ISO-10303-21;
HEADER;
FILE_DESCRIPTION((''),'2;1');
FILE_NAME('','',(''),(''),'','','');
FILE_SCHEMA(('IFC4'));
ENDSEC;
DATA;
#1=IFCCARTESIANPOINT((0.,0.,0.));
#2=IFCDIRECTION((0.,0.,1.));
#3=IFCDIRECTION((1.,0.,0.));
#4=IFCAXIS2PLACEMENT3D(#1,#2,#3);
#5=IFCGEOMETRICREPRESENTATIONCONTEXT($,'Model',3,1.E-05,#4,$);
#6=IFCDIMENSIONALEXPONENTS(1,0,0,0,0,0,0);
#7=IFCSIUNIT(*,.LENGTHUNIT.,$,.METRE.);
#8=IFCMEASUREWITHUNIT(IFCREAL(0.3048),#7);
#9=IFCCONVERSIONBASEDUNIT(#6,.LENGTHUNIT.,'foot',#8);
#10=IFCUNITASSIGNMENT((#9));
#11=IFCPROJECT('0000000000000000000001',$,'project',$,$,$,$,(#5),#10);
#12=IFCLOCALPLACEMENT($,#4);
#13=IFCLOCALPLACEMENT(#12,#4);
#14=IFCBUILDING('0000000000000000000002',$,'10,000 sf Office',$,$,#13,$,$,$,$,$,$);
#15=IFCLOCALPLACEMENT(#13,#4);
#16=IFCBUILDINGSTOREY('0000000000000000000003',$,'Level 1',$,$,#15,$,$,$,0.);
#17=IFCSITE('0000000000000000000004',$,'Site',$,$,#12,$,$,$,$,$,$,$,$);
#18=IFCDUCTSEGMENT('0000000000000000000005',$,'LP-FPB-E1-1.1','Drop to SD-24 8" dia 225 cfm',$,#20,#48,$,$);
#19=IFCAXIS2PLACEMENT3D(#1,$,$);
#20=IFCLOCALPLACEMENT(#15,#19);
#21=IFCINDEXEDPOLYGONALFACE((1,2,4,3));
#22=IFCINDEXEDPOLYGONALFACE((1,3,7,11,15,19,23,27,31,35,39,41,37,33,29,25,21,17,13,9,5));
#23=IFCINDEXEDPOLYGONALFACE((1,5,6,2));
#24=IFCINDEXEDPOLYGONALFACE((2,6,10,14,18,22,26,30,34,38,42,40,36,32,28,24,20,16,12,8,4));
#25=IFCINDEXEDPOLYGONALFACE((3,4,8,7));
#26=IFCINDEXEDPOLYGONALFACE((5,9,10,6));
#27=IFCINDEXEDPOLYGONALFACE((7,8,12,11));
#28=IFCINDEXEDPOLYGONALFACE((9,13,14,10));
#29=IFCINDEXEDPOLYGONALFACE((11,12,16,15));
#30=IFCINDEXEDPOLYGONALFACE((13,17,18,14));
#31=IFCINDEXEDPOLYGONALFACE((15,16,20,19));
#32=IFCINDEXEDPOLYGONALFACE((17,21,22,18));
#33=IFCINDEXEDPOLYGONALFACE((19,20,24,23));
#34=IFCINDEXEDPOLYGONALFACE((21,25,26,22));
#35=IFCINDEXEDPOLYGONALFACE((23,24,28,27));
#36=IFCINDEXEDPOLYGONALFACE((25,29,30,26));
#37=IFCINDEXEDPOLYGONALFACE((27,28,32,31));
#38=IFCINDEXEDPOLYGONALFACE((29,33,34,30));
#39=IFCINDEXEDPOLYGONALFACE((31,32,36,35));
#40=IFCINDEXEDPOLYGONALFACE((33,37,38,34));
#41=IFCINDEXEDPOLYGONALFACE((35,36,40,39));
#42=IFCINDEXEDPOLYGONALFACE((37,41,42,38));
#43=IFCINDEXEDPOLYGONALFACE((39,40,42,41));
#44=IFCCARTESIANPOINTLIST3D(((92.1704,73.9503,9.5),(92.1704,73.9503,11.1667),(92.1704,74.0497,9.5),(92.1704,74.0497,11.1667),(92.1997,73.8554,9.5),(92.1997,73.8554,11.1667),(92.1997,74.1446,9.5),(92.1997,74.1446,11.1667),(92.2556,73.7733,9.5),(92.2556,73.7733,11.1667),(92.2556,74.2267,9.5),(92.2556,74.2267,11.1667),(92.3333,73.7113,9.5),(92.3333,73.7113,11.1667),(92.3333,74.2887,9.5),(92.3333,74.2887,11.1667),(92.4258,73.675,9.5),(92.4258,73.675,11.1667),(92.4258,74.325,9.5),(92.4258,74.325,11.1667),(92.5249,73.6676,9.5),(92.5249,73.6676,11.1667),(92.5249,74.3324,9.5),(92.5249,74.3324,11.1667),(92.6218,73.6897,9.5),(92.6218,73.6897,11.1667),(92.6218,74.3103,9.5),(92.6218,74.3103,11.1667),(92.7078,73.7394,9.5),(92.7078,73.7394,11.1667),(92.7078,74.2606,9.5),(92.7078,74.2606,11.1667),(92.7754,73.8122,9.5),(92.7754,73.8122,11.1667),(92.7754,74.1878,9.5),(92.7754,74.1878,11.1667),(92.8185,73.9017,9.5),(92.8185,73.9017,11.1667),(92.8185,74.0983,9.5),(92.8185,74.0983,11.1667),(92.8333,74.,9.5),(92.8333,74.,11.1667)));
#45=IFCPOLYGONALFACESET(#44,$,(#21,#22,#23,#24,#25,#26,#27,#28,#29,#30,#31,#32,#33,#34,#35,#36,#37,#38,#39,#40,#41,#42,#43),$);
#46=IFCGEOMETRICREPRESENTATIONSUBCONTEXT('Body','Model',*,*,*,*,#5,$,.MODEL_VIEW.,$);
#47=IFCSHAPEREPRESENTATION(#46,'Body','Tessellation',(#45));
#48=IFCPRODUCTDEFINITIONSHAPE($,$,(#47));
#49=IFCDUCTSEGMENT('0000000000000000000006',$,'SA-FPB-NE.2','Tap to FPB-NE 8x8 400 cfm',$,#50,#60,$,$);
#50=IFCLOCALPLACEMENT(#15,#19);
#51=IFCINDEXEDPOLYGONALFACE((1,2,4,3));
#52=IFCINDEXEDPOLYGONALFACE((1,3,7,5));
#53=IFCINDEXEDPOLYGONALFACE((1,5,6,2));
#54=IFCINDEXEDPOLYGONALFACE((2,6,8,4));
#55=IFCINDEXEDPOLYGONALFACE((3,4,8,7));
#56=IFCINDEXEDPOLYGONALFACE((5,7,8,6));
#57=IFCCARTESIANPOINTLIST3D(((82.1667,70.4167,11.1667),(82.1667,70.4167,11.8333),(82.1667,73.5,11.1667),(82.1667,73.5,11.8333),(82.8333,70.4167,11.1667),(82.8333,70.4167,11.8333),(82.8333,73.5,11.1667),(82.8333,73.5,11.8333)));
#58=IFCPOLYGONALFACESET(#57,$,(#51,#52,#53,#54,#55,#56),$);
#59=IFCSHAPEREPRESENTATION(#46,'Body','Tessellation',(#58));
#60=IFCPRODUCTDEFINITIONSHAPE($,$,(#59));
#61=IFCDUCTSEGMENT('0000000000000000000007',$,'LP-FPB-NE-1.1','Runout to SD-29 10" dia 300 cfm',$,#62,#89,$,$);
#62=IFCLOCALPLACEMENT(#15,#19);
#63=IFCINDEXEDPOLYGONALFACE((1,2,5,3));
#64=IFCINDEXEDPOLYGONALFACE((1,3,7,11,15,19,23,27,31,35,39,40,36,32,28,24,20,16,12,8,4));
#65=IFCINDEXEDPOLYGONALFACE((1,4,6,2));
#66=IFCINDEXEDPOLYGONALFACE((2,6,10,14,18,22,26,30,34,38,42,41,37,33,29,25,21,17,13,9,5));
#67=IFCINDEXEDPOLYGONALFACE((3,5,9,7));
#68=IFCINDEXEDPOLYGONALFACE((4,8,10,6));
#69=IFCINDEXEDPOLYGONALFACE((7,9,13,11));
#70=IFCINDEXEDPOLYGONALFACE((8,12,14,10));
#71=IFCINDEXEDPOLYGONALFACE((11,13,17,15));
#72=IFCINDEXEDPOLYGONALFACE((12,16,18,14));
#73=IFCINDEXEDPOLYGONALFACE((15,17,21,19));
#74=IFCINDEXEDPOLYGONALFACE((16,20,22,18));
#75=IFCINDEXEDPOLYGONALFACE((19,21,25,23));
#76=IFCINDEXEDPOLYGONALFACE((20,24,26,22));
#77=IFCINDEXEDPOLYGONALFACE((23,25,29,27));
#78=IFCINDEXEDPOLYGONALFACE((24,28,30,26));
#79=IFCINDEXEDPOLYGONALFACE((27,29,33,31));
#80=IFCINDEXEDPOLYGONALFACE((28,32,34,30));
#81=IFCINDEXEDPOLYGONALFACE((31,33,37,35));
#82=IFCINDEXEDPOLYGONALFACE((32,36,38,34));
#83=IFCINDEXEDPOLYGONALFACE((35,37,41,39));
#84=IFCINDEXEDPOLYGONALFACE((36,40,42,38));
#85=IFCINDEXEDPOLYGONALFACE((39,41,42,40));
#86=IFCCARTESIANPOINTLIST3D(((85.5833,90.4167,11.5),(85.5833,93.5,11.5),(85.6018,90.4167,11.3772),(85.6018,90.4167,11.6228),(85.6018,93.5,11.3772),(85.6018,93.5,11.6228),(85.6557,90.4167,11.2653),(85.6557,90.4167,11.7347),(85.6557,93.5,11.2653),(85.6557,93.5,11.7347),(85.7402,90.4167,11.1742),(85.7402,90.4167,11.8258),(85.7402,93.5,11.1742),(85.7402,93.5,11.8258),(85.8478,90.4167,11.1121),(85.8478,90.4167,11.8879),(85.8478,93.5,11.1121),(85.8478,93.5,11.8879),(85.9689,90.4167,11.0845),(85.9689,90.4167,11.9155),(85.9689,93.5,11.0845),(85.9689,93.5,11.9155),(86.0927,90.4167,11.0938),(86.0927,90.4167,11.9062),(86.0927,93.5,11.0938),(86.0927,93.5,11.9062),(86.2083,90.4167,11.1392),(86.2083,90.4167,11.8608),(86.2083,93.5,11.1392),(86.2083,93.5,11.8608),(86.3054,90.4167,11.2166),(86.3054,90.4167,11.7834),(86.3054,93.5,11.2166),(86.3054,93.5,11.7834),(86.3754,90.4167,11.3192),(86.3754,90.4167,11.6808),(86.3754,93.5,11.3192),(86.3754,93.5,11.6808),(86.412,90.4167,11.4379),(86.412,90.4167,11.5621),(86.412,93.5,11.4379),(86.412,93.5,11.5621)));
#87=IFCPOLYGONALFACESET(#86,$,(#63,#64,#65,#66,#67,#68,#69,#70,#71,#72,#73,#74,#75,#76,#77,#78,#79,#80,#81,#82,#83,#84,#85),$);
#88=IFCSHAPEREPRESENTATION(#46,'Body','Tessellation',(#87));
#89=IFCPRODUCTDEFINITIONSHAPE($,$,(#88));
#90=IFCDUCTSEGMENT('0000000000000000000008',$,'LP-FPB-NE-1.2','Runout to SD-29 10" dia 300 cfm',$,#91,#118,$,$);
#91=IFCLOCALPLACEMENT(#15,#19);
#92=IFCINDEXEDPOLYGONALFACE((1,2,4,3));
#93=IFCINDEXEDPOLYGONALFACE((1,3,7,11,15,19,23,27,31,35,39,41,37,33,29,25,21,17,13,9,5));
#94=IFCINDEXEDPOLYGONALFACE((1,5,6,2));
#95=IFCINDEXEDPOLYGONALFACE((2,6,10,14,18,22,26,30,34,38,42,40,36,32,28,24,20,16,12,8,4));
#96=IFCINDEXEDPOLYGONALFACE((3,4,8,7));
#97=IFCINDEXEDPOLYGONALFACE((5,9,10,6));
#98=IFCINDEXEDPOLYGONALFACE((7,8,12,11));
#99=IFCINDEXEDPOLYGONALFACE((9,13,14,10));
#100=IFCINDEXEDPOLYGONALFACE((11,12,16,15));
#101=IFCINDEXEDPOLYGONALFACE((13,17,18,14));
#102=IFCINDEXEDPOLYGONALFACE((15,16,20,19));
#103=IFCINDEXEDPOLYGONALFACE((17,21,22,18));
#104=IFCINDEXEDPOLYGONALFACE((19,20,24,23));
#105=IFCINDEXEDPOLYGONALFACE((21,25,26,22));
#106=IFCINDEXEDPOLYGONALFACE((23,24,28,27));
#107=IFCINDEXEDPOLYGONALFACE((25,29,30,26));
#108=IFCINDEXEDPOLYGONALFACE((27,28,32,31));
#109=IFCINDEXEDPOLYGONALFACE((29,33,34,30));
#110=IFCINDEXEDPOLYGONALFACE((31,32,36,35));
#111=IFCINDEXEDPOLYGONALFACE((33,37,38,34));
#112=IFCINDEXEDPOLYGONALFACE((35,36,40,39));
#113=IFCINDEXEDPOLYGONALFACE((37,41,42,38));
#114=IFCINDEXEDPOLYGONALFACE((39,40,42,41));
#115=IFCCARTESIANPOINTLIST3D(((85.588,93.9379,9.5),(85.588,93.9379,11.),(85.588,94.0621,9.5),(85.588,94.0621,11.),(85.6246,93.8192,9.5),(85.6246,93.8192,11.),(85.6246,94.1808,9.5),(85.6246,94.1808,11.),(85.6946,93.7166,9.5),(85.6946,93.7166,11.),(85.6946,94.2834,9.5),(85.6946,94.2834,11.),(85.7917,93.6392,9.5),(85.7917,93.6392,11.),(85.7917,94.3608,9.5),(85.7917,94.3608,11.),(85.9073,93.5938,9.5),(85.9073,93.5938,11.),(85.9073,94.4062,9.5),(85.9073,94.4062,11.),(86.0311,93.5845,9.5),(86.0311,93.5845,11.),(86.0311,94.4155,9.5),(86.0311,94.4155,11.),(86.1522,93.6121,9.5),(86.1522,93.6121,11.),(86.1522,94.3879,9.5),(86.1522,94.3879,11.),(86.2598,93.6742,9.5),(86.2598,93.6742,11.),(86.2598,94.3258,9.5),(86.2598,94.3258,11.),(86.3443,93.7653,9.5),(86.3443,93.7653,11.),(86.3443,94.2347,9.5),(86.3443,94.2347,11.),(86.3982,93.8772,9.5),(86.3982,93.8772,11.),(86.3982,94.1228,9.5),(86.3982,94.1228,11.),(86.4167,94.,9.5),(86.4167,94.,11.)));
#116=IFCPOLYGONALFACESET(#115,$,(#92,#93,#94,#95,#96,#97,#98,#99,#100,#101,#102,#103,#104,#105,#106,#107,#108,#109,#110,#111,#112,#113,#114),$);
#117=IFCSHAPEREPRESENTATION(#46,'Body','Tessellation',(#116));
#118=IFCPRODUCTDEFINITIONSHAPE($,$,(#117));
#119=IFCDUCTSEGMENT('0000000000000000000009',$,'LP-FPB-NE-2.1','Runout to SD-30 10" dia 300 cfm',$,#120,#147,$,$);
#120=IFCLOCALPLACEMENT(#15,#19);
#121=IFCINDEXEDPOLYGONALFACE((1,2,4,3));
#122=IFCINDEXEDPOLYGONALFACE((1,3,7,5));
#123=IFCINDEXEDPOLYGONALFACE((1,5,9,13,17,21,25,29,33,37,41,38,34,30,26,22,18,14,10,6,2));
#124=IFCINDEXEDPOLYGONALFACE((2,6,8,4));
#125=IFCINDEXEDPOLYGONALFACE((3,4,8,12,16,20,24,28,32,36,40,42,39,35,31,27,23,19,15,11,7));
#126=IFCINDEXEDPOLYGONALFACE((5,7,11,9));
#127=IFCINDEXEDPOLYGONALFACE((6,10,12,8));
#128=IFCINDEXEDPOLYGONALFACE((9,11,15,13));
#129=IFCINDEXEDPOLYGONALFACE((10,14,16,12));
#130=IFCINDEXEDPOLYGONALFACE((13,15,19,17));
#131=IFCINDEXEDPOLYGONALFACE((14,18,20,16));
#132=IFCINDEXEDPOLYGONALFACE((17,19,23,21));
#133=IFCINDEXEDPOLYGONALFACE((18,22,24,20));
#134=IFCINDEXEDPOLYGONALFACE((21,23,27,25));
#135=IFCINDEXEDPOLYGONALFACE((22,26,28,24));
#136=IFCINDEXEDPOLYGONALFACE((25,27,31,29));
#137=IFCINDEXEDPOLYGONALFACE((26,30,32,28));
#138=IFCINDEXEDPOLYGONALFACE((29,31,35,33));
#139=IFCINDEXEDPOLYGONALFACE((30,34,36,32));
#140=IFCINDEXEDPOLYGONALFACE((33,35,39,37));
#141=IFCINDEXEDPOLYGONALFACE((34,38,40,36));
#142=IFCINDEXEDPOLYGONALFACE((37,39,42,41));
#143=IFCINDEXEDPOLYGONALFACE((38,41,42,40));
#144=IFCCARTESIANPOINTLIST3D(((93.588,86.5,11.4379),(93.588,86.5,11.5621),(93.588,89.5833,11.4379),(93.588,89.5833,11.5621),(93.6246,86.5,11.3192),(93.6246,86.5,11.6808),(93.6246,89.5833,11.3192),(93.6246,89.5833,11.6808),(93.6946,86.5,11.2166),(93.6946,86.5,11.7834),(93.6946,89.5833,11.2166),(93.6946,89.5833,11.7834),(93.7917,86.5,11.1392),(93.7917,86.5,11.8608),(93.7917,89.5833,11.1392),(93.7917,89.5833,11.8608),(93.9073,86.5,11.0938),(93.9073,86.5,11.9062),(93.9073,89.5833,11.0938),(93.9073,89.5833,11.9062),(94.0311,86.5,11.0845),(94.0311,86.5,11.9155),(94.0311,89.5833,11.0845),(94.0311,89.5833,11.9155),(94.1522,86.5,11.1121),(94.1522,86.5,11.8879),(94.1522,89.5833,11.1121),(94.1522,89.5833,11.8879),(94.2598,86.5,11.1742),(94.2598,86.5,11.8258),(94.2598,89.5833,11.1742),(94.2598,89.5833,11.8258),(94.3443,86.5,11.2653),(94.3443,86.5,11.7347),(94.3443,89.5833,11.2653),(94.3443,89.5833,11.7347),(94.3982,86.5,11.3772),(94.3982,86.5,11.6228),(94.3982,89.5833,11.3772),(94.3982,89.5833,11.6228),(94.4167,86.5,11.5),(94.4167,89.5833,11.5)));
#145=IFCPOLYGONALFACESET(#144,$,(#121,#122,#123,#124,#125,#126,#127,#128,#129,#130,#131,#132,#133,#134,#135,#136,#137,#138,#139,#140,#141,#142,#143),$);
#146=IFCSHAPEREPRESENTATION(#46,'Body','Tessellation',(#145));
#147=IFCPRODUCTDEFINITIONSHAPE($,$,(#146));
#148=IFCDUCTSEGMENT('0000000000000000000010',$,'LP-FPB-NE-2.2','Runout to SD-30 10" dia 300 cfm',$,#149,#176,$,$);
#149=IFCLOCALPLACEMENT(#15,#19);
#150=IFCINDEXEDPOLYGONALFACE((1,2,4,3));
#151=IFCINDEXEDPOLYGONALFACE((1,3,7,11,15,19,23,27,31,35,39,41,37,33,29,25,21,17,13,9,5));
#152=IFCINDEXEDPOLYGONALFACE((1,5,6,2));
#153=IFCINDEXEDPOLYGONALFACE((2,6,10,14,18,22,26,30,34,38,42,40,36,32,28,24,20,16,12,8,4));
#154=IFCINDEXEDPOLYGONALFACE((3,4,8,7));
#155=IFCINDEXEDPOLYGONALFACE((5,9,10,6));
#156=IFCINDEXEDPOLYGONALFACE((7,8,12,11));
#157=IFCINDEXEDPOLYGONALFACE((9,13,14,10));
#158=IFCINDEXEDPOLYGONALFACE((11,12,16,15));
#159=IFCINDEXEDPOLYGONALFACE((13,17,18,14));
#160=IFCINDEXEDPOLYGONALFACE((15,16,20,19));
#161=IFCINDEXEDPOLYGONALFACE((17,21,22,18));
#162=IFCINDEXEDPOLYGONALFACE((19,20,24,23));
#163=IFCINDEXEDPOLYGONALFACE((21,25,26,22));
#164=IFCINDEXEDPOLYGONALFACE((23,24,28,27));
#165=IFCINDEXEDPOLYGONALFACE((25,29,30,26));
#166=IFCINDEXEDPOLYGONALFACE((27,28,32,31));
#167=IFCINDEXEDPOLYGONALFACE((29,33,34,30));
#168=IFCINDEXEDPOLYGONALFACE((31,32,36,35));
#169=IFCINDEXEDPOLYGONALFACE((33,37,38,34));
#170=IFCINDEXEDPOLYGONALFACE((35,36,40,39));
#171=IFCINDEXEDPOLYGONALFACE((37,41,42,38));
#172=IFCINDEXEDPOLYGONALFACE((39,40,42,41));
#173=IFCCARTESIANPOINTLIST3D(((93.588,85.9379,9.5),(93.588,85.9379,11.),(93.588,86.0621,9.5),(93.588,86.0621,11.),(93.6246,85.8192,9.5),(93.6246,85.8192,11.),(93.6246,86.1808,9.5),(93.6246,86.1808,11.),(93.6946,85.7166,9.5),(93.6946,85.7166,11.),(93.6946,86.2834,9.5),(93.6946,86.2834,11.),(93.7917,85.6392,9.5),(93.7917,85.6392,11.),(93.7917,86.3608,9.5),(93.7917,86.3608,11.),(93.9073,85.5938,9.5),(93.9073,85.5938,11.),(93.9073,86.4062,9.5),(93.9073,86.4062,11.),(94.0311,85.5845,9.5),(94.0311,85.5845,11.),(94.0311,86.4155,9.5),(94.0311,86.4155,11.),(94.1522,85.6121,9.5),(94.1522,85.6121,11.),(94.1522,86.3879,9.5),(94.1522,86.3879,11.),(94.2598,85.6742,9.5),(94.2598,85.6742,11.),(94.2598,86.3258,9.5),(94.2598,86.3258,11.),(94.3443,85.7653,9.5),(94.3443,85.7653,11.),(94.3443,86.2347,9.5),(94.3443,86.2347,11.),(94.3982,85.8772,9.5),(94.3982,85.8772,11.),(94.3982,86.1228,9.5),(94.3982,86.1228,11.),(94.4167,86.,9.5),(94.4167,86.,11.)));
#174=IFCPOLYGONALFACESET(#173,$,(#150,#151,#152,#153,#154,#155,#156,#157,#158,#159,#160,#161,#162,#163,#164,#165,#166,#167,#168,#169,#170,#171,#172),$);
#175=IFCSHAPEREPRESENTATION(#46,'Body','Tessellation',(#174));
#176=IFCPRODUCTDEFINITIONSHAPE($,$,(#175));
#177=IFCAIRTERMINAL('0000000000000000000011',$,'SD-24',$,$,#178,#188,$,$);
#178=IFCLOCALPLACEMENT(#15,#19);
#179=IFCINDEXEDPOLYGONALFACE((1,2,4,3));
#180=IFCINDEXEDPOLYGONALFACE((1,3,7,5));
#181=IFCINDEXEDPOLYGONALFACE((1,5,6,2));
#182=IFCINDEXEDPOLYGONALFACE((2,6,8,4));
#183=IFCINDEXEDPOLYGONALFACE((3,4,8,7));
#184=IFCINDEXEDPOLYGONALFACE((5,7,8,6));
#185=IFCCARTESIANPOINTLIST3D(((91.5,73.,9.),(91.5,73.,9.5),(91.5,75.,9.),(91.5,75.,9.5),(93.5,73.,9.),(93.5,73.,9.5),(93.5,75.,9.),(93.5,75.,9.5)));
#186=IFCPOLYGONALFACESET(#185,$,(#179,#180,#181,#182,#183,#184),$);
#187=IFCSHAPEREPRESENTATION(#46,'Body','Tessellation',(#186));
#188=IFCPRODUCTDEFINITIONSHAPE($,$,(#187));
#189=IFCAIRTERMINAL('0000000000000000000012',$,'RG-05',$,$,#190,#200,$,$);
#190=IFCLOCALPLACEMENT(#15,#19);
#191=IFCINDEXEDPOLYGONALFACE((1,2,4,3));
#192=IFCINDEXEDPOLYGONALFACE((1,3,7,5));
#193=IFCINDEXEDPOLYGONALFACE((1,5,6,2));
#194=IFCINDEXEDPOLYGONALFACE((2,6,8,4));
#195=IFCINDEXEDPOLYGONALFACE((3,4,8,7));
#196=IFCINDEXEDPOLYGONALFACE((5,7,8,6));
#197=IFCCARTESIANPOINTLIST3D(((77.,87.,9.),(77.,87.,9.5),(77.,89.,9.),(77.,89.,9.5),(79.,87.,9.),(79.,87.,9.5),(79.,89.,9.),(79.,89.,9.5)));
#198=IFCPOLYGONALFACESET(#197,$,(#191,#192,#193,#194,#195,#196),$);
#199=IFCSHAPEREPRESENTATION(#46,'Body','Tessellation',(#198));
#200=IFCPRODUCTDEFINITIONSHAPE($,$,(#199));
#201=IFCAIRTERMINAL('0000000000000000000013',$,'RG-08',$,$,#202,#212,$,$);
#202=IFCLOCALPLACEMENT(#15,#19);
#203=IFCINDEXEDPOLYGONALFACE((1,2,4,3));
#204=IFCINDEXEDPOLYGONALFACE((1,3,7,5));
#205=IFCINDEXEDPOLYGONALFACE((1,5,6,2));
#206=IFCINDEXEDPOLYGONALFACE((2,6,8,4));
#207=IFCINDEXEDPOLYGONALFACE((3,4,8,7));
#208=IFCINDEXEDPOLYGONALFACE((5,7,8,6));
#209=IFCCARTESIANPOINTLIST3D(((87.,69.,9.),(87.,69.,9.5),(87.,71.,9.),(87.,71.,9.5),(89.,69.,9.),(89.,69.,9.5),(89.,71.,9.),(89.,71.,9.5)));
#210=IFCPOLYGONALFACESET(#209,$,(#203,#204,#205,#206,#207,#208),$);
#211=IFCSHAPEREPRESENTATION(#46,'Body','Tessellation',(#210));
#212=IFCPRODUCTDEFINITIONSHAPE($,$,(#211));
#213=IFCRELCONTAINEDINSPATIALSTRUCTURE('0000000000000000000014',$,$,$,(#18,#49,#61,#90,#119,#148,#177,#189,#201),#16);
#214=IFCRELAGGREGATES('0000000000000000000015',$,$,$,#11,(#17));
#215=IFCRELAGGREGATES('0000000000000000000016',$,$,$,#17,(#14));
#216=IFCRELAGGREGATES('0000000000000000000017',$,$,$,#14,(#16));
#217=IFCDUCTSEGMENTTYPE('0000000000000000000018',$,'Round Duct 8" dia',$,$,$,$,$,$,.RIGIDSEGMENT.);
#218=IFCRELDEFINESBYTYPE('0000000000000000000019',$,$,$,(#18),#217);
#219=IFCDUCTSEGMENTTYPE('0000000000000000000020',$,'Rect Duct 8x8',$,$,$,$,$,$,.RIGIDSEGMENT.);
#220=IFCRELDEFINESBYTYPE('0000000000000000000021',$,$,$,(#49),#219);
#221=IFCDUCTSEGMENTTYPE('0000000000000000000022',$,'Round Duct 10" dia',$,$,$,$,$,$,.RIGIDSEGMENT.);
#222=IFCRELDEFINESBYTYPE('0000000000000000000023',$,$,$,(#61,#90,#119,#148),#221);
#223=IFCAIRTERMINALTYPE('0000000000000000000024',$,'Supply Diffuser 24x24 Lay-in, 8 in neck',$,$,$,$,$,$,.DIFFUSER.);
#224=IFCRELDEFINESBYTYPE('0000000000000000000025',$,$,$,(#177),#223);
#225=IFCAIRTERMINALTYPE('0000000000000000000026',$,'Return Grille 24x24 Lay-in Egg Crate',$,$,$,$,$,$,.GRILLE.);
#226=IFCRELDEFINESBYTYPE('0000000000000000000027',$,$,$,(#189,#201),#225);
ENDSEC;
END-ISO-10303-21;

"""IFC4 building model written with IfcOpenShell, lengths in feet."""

from ifc_helpers import new_model, entity, si_unit, converted_unit, frame, origin_with_axes, place, context, subcontext, project, spatial, rectangle, circle, extrude, type_object, element, save


model = new_model("IFC4")

# Units and contexts
model_context = context("Model", 3, precision=1e-05, world=origin_with_axes())
body_context = subcontext(model_context, "Body", "Model", "MODEL_VIEW")
ifc_project = project(units=[converted_unit("LENGTHUNIT", "foot", entity("IfcReal", 0.3048), si_unit("LENGTHUNIT", "METRE"), dimensions=[1, 0, 0, 0, 0, 0, 0])], contexts=[model_context])

# Site, building, storey
site_placement = place(None, origin_with_axes())
site = spatial("IfcSite", under=ifc_project, at=site_placement, Name="Site")
building_placement = place(site_placement, origin_with_axes())
building = spatial("IfcBuilding", under=site, at=building_placement, Name="10,000 sf Office")
storey_placement = place(building_placement, origin_with_axes())
storey = spatial("IfcBuildingStorey", under=building, at=storey_placement, Name="Level 1", Elevation=0.0)

# Duct segments
duct_segment_type_1 = type_object("IfcDuctSegmentType", Name="Round Duct 8\" dia", PredefinedType="RIGIDSEGMENT")
duct_segment_1_placement = place(storey_placement, frame((92.5, 74.0, 11.1667), z_axis=(0.0, 0.0, -1.0), x_axis=(1.0, 0.0, 0.0)))
element("IfcDuctSegment", 1, at=duct_segment_1_placement, inside=storey, type_object=duct_segment_type_1, Name="LP-FPB-E1-1.1", Description="Drop to SD-24 8\" dia 225 cfm", context=body_context, shape_type="SweptSolid", body=[
    extrude(circle(Radius=0.3333), None, (0.0, 0.0, 1.0), 1.6667),
])
duct_segment_type_2 = type_object("IfcDuctSegmentType", Name="Rect Duct 8x8", PredefinedType="RIGIDSEGMENT")
duct_segment_2_placement = place(storey_placement, frame((82.5, 70.4167, 11.5), z_axis=(0.0, 1.0, 0.0), x_axis=(-1.0, 0.0, 0.0)))
element("IfcDuctSegment", 2, at=duct_segment_2_placement, inside=storey, type_object=duct_segment_type_2, Name="SA-FPB-NE.2", Description="Tap to FPB-NE 8x8 400 cfm", context=body_context, shape_type="SweptSolid", body=[
    extrude(rectangle(XDim=0.6667, YDim=0.6667), None, (0.0, 0.0, 1.0), 3.0833),
])
duct_segment_type_3 = type_object("IfcDuctSegmentType", Name="Round Duct 10\" dia", PredefinedType="RIGIDSEGMENT")
duct_segment_3_placement = place(storey_placement, frame((86.0, 90.4167, 11.5), z_axis=(0.0, 1.0, 0.0), x_axis=(-1.0, 0.0, 0.0)))
element("IfcDuctSegment", 3, at=duct_segment_3_placement, inside=storey, type_object=duct_segment_type_3, Name="LP-FPB-NE-1.1", Description="Runout to SD-29 10\" dia 300 cfm", context=body_context, shape_type="SweptSolid", body=[
    extrude(circle(Radius=0.4167), None, (0.0, 0.0, 1.0), 3.0833),
])
duct_segment_4_placement = place(storey_placement, frame((86.0, 94.0, 11.0), z_axis=(0.0, 0.0, -1.0), x_axis=(1.0, 0.0, 0.0)))
element("IfcDuctSegment", 4, at=duct_segment_4_placement, inside=storey, type_object=duct_segment_type_3, Name="LP-FPB-NE-1.2", Description="Runout to SD-29 10\" dia 300 cfm", context=body_context, shape_type="SweptSolid", body=[
    extrude(circle(Radius=0.4167), None, (0.0, 0.0, 1.0), 1.5),
])
duct_segment_5_placement = place(storey_placement, frame((94.0, 89.5833, 11.5), z_axis=(0.0, -1.0, 0.0), x_axis=(1.0, 0.0, 0.0)))
element("IfcDuctSegment", 5, at=duct_segment_5_placement, inside=storey, type_object=duct_segment_type_3, Name="LP-FPB-NE-2.1", Description="Runout to SD-30 10\" dia 300 cfm", context=body_context, shape_type="SweptSolid", body=[
    extrude(circle(Radius=0.4167), None, (0.0, 0.0, 1.0), 3.0833),
])
duct_segment_6_placement = place(storey_placement, frame((94.0, 86.0, 11.0), z_axis=(0.0, 0.0, -1.0), x_axis=(1.0, 0.0, 0.0)))
element("IfcDuctSegment", 6, at=duct_segment_6_placement, inside=storey, type_object=duct_segment_type_3, Name="LP-FPB-NE-2.2", Description="Runout to SD-30 10\" dia 300 cfm", context=body_context, shape_type="SweptSolid", body=[
    extrude(circle(Radius=0.4167), None, (0.0, 0.0, 1.0), 1.5),
])

# Air terminals
air_terminal_type_1 = type_object("IfcAirTerminalType", Name="Supply Diffuser 24x24 Lay-in, 8 in neck", PredefinedType="DIFFUSER")
air_terminal_placement = place(storey_placement, frame((92.5, 74.0, 9.0), z_axis=(0.0, 0.0, 1.0), x_axis=(1.0, 0.0, 0.0)))
element("IfcAirTerminal", 7, at=air_terminal_placement, inside=storey, type_object=air_terminal_type_1, Name="SD-24", context=body_context, shape_type="SweptSolid", body=[
    extrude(rectangle(XDim=2.0, YDim=2.0), None, (0.0, 0.0, 1.0), 0.5),
])
air_terminal_type_2 = type_object("IfcAirTerminalType", Name="Return Grille 24x24 Lay-in Egg Crate", PredefinedType="GRILLE")
for number, where, z_axis, x_axis, name in (
    (8, (78.0, 88.0, 9.0), (0.0, 0.0, 1.0), (1.0, 0.0, 0.0), "RG-05"),
    (9, (88.0, 70.0, 9.0), (0.0, 0.0, 1.0), (1.0, 0.0, 0.0), "RG-08"),
):
    element("IfcAirTerminal", number, at=place(storey_placement, frame(where, z_axis=z_axis, x_axis=x_axis)), inside=storey, type_object=air_terminal_type_2, Name=name, context=body_context, shape_type="SweptSolid", body=[
        extrude(rectangle(XDim=2.0, YDim=2.0), None, (0.0, 0.0, 1.0), 0.5),
    ])

save(model, "model.ifc")
